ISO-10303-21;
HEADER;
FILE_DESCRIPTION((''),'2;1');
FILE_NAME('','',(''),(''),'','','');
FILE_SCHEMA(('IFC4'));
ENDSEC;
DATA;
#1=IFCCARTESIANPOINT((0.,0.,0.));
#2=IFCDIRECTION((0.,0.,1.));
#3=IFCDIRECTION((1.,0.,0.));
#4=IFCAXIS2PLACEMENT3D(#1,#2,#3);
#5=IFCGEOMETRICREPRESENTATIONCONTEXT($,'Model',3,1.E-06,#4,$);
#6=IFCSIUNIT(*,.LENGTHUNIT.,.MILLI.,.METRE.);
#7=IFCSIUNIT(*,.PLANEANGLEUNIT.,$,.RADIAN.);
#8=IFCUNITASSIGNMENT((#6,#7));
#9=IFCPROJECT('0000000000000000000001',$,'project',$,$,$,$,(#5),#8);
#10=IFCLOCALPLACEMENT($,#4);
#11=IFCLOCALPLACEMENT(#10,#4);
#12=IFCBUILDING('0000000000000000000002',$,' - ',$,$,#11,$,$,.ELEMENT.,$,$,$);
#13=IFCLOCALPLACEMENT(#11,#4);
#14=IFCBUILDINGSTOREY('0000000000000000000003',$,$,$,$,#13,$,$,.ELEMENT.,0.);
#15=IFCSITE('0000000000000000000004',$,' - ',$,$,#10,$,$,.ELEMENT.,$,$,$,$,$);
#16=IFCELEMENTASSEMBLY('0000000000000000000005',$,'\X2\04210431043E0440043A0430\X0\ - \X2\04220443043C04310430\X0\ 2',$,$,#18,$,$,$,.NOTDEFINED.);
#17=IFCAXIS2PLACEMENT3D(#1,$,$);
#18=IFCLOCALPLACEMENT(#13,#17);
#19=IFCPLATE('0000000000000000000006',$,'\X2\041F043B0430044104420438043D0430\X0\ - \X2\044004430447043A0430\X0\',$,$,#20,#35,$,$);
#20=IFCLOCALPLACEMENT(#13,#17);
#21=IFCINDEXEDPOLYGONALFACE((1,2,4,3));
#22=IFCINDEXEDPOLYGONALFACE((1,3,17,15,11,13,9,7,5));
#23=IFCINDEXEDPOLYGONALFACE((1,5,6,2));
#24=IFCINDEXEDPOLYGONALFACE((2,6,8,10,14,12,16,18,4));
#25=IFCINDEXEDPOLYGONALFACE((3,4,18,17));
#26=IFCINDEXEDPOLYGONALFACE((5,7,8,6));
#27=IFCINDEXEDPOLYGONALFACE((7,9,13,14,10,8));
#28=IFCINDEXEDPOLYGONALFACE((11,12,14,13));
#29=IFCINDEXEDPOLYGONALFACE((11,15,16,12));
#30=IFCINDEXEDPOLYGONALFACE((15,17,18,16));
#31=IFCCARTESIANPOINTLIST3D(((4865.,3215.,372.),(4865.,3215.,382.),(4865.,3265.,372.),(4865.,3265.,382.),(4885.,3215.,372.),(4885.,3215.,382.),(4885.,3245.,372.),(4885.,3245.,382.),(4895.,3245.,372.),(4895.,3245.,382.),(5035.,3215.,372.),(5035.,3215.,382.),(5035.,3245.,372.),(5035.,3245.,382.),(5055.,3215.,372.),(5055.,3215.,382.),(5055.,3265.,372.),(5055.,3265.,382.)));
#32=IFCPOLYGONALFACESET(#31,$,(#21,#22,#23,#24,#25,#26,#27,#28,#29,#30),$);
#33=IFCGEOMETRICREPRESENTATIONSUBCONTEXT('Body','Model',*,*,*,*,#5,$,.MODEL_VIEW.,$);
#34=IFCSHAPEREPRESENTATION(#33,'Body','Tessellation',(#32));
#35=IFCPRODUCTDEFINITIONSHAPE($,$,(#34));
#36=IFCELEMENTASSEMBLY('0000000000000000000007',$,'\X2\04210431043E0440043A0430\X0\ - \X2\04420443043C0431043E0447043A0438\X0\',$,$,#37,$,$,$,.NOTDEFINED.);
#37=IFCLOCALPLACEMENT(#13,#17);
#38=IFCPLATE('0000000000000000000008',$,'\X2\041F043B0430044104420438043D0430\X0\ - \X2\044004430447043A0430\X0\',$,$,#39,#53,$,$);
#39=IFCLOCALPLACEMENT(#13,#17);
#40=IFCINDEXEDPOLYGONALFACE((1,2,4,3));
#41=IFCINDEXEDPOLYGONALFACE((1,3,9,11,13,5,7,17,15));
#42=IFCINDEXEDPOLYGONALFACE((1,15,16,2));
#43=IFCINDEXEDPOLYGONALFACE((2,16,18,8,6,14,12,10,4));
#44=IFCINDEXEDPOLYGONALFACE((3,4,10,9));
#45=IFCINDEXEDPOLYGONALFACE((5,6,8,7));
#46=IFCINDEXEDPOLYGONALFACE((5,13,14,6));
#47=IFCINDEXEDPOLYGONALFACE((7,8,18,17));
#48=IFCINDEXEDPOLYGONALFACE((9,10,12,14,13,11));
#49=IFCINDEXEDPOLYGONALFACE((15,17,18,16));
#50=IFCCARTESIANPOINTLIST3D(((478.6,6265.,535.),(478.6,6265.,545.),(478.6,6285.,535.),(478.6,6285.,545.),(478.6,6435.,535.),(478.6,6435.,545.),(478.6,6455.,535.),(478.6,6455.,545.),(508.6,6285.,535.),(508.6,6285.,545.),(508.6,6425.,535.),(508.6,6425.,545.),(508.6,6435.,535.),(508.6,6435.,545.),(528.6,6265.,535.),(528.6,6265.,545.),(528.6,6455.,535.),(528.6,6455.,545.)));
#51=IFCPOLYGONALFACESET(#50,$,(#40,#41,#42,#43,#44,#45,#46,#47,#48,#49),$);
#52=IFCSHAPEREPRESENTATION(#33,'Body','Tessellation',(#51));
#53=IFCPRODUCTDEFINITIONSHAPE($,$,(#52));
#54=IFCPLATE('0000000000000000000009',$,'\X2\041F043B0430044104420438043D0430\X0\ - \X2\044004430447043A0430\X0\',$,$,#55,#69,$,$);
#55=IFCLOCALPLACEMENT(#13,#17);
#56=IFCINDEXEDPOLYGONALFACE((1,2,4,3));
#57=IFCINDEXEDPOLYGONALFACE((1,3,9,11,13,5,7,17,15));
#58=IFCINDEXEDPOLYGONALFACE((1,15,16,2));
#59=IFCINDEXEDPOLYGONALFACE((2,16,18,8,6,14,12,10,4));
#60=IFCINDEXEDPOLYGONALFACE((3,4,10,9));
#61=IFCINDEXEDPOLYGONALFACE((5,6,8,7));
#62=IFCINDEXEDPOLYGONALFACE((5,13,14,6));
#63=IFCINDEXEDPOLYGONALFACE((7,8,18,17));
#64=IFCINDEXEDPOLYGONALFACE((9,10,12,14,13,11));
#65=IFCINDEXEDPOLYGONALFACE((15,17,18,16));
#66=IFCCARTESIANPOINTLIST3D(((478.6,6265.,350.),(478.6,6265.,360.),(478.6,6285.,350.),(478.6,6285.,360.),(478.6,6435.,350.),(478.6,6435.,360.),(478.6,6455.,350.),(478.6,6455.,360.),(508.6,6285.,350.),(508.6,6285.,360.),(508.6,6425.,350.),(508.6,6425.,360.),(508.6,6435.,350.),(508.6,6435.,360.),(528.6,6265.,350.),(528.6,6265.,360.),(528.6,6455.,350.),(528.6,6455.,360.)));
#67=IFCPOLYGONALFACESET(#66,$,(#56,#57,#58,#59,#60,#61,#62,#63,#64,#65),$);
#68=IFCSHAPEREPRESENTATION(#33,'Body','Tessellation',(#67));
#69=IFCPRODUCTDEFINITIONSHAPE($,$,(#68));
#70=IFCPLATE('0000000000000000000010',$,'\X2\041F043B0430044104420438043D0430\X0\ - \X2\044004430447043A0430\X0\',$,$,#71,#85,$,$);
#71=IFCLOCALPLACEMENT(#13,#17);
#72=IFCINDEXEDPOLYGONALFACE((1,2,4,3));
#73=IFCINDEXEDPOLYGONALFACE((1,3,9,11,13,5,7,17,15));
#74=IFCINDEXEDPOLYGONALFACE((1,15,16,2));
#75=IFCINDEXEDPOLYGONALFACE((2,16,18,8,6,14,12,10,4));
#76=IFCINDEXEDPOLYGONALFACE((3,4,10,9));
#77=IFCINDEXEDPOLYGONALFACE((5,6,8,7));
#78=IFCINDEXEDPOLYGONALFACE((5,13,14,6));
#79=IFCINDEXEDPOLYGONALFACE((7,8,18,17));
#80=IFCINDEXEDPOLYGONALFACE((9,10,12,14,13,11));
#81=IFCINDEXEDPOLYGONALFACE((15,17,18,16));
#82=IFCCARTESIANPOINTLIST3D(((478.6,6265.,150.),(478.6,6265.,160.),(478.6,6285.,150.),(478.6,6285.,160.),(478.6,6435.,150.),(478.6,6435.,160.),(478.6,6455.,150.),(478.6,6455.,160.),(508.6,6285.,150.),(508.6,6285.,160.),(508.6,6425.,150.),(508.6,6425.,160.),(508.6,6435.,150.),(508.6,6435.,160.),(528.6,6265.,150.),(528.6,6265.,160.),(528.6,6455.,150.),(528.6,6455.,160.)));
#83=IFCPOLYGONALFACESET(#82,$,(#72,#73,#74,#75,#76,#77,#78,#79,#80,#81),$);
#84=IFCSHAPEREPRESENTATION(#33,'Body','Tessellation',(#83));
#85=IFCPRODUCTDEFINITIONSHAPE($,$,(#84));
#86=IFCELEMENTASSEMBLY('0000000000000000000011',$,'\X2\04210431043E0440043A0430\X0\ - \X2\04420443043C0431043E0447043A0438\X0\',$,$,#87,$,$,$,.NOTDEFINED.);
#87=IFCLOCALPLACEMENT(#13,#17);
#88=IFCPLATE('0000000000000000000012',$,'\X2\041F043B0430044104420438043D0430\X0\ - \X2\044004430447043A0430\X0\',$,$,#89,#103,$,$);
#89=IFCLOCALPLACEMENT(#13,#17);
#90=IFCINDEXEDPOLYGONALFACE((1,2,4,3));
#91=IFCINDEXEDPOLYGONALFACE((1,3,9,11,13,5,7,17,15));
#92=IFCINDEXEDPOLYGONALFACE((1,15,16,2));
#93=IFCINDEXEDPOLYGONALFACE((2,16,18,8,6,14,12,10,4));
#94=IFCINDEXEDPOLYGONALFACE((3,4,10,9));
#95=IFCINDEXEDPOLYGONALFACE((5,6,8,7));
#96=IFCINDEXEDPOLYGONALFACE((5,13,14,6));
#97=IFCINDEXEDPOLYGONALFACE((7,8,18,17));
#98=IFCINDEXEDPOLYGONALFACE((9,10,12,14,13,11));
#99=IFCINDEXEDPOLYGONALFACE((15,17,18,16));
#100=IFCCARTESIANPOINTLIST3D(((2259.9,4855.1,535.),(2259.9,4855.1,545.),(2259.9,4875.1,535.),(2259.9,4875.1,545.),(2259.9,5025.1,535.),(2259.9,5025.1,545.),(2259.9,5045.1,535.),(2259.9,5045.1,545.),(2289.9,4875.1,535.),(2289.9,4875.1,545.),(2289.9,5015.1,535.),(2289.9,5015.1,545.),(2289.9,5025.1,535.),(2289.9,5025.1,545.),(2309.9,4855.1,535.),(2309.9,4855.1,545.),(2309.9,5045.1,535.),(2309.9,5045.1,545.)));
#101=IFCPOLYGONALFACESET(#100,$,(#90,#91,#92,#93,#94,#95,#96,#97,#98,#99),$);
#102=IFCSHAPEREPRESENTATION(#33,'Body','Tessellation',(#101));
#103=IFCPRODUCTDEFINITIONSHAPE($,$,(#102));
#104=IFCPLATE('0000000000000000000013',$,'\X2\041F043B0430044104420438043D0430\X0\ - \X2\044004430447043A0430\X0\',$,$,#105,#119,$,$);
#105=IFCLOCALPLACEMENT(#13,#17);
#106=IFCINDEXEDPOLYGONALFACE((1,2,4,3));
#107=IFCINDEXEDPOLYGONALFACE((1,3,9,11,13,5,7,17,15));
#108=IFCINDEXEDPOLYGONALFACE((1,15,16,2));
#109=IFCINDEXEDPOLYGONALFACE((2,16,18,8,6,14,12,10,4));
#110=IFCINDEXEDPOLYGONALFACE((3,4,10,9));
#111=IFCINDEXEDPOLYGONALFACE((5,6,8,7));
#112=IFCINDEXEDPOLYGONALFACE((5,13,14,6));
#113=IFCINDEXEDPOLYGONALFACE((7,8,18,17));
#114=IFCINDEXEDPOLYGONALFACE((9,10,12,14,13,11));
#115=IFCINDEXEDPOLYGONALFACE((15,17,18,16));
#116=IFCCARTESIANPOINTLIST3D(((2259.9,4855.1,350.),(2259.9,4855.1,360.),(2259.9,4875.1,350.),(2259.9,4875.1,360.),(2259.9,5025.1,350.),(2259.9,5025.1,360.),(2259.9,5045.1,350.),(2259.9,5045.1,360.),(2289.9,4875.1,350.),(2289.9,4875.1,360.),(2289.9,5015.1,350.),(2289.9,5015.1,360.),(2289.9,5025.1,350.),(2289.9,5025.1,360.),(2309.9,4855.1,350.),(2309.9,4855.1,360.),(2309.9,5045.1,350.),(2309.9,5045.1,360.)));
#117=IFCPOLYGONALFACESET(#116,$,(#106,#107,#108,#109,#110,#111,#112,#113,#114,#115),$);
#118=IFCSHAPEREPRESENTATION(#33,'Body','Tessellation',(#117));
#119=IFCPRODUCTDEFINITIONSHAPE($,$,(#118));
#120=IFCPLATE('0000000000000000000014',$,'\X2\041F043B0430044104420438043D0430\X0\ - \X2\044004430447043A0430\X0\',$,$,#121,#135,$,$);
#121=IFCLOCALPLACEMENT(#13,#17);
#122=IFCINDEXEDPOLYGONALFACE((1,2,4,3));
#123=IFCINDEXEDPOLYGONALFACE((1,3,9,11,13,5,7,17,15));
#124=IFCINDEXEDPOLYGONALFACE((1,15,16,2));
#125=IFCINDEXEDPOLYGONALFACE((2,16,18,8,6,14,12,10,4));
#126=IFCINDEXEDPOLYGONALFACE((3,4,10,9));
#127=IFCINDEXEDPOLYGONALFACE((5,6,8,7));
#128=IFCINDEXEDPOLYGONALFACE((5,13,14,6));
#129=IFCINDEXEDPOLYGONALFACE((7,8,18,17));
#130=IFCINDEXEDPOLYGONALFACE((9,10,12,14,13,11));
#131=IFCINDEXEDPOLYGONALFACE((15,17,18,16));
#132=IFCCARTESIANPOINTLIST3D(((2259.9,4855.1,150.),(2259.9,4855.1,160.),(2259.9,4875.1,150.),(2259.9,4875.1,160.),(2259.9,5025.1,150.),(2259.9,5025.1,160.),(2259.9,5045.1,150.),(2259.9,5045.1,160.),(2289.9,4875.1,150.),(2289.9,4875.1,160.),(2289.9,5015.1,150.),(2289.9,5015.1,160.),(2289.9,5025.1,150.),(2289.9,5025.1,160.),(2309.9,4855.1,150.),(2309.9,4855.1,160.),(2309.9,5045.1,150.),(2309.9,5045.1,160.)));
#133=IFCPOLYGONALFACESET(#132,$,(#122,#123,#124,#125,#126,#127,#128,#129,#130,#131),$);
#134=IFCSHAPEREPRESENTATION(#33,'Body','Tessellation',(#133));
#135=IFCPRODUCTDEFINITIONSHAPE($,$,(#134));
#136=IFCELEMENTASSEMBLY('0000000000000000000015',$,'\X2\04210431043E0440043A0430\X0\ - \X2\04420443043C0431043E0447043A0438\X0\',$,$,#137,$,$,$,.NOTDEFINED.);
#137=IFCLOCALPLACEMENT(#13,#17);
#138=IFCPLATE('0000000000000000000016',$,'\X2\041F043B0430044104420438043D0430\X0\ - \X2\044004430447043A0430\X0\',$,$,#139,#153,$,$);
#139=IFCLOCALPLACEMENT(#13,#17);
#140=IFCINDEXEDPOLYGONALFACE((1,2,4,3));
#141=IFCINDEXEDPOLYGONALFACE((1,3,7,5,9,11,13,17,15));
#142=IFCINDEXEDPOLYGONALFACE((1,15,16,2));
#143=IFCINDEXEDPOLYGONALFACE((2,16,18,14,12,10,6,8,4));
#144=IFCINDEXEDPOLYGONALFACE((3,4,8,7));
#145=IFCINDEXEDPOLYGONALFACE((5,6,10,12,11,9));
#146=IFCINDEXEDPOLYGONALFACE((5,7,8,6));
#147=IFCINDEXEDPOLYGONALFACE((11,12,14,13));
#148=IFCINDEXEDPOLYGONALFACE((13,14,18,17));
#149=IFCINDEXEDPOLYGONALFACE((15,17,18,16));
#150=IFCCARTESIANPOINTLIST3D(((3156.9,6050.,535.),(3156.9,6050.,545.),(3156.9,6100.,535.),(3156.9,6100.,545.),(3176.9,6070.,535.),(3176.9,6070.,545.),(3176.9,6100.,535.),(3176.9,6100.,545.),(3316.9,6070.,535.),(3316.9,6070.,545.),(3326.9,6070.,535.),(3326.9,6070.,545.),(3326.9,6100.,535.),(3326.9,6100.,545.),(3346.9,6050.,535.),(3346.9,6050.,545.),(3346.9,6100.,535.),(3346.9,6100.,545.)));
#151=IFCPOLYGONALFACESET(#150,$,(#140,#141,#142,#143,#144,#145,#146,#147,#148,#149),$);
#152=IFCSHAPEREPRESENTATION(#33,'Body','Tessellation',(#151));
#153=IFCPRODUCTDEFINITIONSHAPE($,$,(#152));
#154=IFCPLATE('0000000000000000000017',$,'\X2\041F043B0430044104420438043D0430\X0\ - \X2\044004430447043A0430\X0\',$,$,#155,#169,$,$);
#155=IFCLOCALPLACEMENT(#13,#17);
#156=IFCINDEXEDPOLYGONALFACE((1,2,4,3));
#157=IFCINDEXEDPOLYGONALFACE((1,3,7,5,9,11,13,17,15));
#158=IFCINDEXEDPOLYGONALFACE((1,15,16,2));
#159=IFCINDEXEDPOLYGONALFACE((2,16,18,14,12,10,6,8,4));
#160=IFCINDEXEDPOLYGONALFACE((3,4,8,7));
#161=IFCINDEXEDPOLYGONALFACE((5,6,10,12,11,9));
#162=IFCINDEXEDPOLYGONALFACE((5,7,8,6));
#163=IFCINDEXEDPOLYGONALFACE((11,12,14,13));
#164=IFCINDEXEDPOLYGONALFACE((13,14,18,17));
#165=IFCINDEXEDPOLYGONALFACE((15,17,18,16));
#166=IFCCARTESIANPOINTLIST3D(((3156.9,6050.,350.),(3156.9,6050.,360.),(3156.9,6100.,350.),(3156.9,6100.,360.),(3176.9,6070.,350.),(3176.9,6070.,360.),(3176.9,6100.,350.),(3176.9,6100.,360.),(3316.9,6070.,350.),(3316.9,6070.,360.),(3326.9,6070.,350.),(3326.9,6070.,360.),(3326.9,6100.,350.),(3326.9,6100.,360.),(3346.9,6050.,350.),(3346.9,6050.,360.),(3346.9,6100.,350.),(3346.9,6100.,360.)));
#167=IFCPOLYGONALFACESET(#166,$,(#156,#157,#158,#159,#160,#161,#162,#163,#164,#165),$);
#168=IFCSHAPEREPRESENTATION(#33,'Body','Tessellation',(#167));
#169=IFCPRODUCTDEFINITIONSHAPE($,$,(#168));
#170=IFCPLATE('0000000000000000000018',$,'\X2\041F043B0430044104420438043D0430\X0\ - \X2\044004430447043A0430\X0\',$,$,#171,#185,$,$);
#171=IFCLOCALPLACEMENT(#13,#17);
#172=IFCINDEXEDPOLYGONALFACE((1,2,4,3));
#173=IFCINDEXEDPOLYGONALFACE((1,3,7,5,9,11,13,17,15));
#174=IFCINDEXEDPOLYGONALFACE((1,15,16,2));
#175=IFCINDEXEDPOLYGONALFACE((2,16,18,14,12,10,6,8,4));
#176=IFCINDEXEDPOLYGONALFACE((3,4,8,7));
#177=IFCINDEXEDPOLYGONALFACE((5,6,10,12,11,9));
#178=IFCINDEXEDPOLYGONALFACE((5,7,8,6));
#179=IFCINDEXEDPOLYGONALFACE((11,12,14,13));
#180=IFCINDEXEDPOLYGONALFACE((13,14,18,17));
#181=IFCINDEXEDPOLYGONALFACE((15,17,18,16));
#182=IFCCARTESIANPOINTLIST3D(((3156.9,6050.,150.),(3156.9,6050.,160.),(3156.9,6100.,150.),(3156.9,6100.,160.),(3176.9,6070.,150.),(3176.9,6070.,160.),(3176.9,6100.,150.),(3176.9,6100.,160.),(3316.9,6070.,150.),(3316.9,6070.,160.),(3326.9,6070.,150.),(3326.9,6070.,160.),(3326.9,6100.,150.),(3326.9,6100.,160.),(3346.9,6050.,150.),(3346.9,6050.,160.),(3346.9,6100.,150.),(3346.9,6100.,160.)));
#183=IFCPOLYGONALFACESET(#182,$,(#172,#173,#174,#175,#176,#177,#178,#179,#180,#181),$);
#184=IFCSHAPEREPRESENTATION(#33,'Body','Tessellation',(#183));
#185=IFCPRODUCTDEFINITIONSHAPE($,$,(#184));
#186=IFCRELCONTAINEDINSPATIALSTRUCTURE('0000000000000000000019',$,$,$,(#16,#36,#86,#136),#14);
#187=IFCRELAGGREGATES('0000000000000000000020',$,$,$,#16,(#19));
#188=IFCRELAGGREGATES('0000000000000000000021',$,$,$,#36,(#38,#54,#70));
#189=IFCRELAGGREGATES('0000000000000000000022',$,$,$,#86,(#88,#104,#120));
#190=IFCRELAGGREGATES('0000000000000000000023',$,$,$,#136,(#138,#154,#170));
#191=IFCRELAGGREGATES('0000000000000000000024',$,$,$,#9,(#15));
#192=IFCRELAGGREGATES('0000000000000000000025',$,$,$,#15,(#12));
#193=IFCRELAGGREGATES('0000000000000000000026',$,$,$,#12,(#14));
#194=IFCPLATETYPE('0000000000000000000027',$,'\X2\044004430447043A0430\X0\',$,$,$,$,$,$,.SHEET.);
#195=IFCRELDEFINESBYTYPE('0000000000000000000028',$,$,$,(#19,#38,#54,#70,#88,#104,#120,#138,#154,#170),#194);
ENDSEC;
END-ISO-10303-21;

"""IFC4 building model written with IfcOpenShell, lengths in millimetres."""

from ifc_helpers import new_model, si_unit, frame, origin_with_axes, place, context, subcontext, project, spatial, line, indexed_curve, outline, extrude, source, transform, mapped, type_object, element, aggregate, save


model = new_model("IFC4")

# Units and contexts
model_context = context("Model", 3, precision=1e-06, world=origin_with_axes())
body_context = subcontext(model_context, "Body", "Model", "MODEL_VIEW")
ifc_project = project(units=[si_unit("LENGTHUNIT", "METRE", prefix="MILLI"), si_unit("PLANEANGLEUNIT", "RADIAN")], contexts=[model_context])

# Site, building, storey
site_placement = place(None, origin_with_axes())
site = spatial("IfcSite", under=ifc_project, at=site_placement, Name=" - ", CompositionType="ELEMENT")
building_placement = place(site_placement, origin_with_axes())
building = spatial("IfcBuilding", under=site, at=building_placement, Name=" - ", CompositionType="ELEMENT")
storey_placement = place(building_placement, origin_with_axes())
storey = spatial("IfcBuildingStorey", under=building, at=storey_placement, CompositionType="ELEMENT", Elevation=0.0)

# Element assemblies, plates
assembly_1_placement = place(storey_placement, frame((4960.0, 3000.0, 2.0), z_axis=(0.0, 0.0, 1.0), x_axis=(-1.0, 0.0, 0.0)))
assembly_1 = element("IfcElementAssembly", 1, at=assembly_1_placement, inside=storey, Name="Сборка - Тумба 2", PredefinedType="NOTDEFINED")
plate_type = type_object("IfcPlateType", Name="ручка", PredefinedType="SHEET")
shared_shape_1 = source(origin_with_axes(), body_context, "Body", "SweptSolid", [
    extrude(outline(indexed_curve([(-95.0, -25.0), (-75.0, -25.0), (-75.0, 5.0), (-65.0, 5.0), (75.0, 5.0), (75.0, -25.0), (95.0, -25.0), (95.0, 25.0), (-95.0, 25.0)], segments=[line(1, 2), line(2, 3), line(3, 4), line(4, 5), line(5, 6), line(6, 7), line(7, 8), line(8, 9), line(9, 1)])), origin_with_axes(), (0.0, 0.0, 1.0), 10.0),
])
plate_1_placement = place(assembly_1_placement, frame((0.0, -240.0, 370.0), z_axis=(0.0, 0.0, 1.0), x_axis=(-1.0, 0.0, 0.0)))
plate_1 = element("IfcPlate", 2, at=plate_1_placement, type_object=plate_type, Name="Пластина - ручка", context=body_context, shape_type="MappedRepresentation", body=[
    mapped(shared_shape_1, transform((0.0, 0.0, 0.0), x_axis=(1.0, 0.0, 0.0), y_axis=(0.0, 1.0, 0.0), z_axis=(0.0, 0.0, 1.0), scale=1.0)),
])
aggregate(assembly_1, [plate_1])
assembly_2_placement = place(storey_placement, frame((478.6, 6160.0, 0.0), z_axis=(0.0, 0.0, 1.0), x_axis=(0.0, 1.0, 0.0)))
assembly_2 = element("IfcElementAssembly", 3, at=assembly_2_placement, inside=storey, Name="Сборка - тумбочки", PredefinedType="NOTDEFINED")
plate_2_placement = place(assembly_2_placement, frame((200.0, -25.0, 535.0), z_axis=(0.0, 0.0, 1.0), x_axis=(-1.0, 0.0, 0.0)))
plate_2 = element("IfcPlate", 4, at=plate_2_placement, type_object=plate_type, Name="Пластина - ручка", context=body_context, shape_type="MappedRepresentation", body=[
    mapped(shared_shape_1, transform((0.0, 0.0, 0.0), x_axis=(1.0, 0.0, 0.0), y_axis=(0.0, 1.0, 0.0), z_axis=(0.0, 0.0, 1.0), scale=1.0)),
])
plate_3_placement = place(assembly_2_placement, frame((200.0, -25.0, 350.0), z_axis=(0.0, 0.0, 1.0), x_axis=(-1.0, 0.0, 0.0)))
plate_3 = element("IfcPlate", 5, at=plate_3_placement, type_object=plate_type, Name="Пластина - ручка", context=body_context, shape_type="MappedRepresentation", body=[
    mapped(shared_shape_1, transform((0.0, 0.0, 0.0), x_axis=(1.0, 0.0, 0.0), y_axis=(0.0, 1.0, 0.0), z_axis=(0.0, 0.0, 1.0), scale=1.0)),
])
plate_4_placement = place(assembly_2_placement, frame((200.0, -25.0, 150.0), z_axis=(0.0, 0.0, 1.0), x_axis=(-1.0, 0.0, 0.0)))
plate_4 = element("IfcPlate", 6, at=plate_4_placement, type_object=plate_type, Name="Пластина - ручка", context=body_context, shape_type="MappedRepresentation", body=[
    mapped(shared_shape_1, transform((0.0, 0.0, 0.0), x_axis=(1.0, 0.0, 0.0), y_axis=(0.0, 1.0, 0.0), z_axis=(0.0, 0.0, 1.0), scale=1.0)),
])
aggregate(assembly_2, [plate_2, plate_3, plate_4])
assembly_3_placement = place(storey_placement, frame((2259.9, 4750.1, 0.0), z_axis=(0.0, 0.0, 1.0), x_axis=(0.0, 1.0, 0.0)))
assembly_3 = element("IfcElementAssembly", 7, at=assembly_3_placement, inside=storey, Name="Сборка - тумбочки", PredefinedType="NOTDEFINED")
plate_5_placement = place(assembly_3_placement, frame((200.0, -25.0, 535.0), z_axis=(0.0, 0.0, 1.0), x_axis=(-1.0, 0.0, 0.0)))
plate_5 = element("IfcPlate", 8, at=plate_5_placement, type_object=plate_type, Name="Пластина - ручка", context=body_context, shape_type="MappedRepresentation", body=[
    mapped(shared_shape_1, transform((0.0, 0.0, 0.0), x_axis=(1.0, 0.0, 0.0), y_axis=(0.0, 1.0, 0.0), z_axis=(0.0, 0.0, 1.0), scale=1.0)),
])
plate_6_placement = place(assembly_3_placement, frame((200.0, -25.0, 350.0), z_axis=(0.0, 0.0, 1.0), x_axis=(-1.0, 0.0, 0.0)))
plate_6 = element("IfcPlate", 9, at=plate_6_placement, type_object=plate_type, Name="Пластина - ручка", context=body_context, shape_type="MappedRepresentation", body=[
    mapped(shared_shape_1, transform((0.0, 0.0, 0.0), x_axis=(1.0, 0.0, 0.0), y_axis=(0.0, 1.0, 0.0), z_axis=(0.0, 0.0, 1.0), scale=1.0)),
])
plate_7_placement = place(assembly_3_placement, frame((200.0, -25.0, 150.0), z_axis=(0.0, 0.0, 1.0), x_axis=(-1.0, 0.0, 0.0)))
plate_7 = element("IfcPlate", 10, at=plate_7_placement, type_object=plate_type, Name="Пластина - ручка", context=body_context, shape_type="MappedRepresentation", body=[
    mapped(shared_shape_1, transform((0.0, 0.0, 0.0), x_axis=(1.0, 0.0, 0.0), y_axis=(0.0, 1.0, 0.0), z_axis=(0.0, 0.0, 1.0), scale=1.0)),
])
aggregate(assembly_3, [plate_5, plate_6, plate_7])
assembly_4_placement = place(storey_placement, frame((3051.9, 6100.0, 0.0), z_axis=(0.0, 0.0, 1.0), x_axis=(1.0, 0.0, 0.0)))
assembly_4 = element("IfcElementAssembly", 11, at=assembly_4_placement, inside=storey, Name="Сборка - тумбочки", PredefinedType="NOTDEFINED")
plate_8_placement = place(assembly_4_placement, frame((200.0, -25.0, 535.0), z_axis=(0.0, 0.0, 1.0), x_axis=(-1.0, 0.0, 0.0)))
plate_8 = element("IfcPlate", 12, at=plate_8_placement, type_object=plate_type, Name="Пластина - ручка", context=body_context, shape_type="MappedRepresentation", body=[
    mapped(shared_shape_1, transform((0.0, 0.0, 0.0), x_axis=(1.0, 0.0, 0.0), y_axis=(0.0, 1.0, 0.0), z_axis=(0.0, 0.0, 1.0), scale=1.0)),
])
plate_9_placement = place(assembly_4_placement, frame((200.0, -25.0, 350.0), z_axis=(0.0, 0.0, 1.0), x_axis=(-1.0, 0.0, 0.0)))
plate_9 = element("IfcPlate", 13, at=plate_9_placement, type_object=plate_type, Name="Пластина - ручка", context=body_context, shape_type="MappedRepresentation", body=[
    mapped(shared_shape_1, transform((0.0, 0.0, 0.0), x_axis=(1.0, 0.0, 0.0), y_axis=(0.0, 1.0, 0.0), z_axis=(0.0, 0.0, 1.0), scale=1.0)),
])
plate_10_placement = place(assembly_4_placement, frame((200.0, -25.0, 150.0), z_axis=(0.0, 0.0, 1.0), x_axis=(-1.0, 0.0, 0.0)))
plate_10 = element("IfcPlate", 14, at=plate_10_placement, type_object=plate_type, Name="Пластина - ручка", context=body_context, shape_type="MappedRepresentation", body=[
    mapped(shared_shape_1, transform((0.0, 0.0, 0.0), x_axis=(1.0, 0.0, 0.0), y_axis=(0.0, 1.0, 0.0), z_axis=(0.0, 0.0, 1.0), scale=1.0)),
])
aggregate(assembly_4, [plate_8, plate_9, plate_10])

save(model, "model.ifc")
